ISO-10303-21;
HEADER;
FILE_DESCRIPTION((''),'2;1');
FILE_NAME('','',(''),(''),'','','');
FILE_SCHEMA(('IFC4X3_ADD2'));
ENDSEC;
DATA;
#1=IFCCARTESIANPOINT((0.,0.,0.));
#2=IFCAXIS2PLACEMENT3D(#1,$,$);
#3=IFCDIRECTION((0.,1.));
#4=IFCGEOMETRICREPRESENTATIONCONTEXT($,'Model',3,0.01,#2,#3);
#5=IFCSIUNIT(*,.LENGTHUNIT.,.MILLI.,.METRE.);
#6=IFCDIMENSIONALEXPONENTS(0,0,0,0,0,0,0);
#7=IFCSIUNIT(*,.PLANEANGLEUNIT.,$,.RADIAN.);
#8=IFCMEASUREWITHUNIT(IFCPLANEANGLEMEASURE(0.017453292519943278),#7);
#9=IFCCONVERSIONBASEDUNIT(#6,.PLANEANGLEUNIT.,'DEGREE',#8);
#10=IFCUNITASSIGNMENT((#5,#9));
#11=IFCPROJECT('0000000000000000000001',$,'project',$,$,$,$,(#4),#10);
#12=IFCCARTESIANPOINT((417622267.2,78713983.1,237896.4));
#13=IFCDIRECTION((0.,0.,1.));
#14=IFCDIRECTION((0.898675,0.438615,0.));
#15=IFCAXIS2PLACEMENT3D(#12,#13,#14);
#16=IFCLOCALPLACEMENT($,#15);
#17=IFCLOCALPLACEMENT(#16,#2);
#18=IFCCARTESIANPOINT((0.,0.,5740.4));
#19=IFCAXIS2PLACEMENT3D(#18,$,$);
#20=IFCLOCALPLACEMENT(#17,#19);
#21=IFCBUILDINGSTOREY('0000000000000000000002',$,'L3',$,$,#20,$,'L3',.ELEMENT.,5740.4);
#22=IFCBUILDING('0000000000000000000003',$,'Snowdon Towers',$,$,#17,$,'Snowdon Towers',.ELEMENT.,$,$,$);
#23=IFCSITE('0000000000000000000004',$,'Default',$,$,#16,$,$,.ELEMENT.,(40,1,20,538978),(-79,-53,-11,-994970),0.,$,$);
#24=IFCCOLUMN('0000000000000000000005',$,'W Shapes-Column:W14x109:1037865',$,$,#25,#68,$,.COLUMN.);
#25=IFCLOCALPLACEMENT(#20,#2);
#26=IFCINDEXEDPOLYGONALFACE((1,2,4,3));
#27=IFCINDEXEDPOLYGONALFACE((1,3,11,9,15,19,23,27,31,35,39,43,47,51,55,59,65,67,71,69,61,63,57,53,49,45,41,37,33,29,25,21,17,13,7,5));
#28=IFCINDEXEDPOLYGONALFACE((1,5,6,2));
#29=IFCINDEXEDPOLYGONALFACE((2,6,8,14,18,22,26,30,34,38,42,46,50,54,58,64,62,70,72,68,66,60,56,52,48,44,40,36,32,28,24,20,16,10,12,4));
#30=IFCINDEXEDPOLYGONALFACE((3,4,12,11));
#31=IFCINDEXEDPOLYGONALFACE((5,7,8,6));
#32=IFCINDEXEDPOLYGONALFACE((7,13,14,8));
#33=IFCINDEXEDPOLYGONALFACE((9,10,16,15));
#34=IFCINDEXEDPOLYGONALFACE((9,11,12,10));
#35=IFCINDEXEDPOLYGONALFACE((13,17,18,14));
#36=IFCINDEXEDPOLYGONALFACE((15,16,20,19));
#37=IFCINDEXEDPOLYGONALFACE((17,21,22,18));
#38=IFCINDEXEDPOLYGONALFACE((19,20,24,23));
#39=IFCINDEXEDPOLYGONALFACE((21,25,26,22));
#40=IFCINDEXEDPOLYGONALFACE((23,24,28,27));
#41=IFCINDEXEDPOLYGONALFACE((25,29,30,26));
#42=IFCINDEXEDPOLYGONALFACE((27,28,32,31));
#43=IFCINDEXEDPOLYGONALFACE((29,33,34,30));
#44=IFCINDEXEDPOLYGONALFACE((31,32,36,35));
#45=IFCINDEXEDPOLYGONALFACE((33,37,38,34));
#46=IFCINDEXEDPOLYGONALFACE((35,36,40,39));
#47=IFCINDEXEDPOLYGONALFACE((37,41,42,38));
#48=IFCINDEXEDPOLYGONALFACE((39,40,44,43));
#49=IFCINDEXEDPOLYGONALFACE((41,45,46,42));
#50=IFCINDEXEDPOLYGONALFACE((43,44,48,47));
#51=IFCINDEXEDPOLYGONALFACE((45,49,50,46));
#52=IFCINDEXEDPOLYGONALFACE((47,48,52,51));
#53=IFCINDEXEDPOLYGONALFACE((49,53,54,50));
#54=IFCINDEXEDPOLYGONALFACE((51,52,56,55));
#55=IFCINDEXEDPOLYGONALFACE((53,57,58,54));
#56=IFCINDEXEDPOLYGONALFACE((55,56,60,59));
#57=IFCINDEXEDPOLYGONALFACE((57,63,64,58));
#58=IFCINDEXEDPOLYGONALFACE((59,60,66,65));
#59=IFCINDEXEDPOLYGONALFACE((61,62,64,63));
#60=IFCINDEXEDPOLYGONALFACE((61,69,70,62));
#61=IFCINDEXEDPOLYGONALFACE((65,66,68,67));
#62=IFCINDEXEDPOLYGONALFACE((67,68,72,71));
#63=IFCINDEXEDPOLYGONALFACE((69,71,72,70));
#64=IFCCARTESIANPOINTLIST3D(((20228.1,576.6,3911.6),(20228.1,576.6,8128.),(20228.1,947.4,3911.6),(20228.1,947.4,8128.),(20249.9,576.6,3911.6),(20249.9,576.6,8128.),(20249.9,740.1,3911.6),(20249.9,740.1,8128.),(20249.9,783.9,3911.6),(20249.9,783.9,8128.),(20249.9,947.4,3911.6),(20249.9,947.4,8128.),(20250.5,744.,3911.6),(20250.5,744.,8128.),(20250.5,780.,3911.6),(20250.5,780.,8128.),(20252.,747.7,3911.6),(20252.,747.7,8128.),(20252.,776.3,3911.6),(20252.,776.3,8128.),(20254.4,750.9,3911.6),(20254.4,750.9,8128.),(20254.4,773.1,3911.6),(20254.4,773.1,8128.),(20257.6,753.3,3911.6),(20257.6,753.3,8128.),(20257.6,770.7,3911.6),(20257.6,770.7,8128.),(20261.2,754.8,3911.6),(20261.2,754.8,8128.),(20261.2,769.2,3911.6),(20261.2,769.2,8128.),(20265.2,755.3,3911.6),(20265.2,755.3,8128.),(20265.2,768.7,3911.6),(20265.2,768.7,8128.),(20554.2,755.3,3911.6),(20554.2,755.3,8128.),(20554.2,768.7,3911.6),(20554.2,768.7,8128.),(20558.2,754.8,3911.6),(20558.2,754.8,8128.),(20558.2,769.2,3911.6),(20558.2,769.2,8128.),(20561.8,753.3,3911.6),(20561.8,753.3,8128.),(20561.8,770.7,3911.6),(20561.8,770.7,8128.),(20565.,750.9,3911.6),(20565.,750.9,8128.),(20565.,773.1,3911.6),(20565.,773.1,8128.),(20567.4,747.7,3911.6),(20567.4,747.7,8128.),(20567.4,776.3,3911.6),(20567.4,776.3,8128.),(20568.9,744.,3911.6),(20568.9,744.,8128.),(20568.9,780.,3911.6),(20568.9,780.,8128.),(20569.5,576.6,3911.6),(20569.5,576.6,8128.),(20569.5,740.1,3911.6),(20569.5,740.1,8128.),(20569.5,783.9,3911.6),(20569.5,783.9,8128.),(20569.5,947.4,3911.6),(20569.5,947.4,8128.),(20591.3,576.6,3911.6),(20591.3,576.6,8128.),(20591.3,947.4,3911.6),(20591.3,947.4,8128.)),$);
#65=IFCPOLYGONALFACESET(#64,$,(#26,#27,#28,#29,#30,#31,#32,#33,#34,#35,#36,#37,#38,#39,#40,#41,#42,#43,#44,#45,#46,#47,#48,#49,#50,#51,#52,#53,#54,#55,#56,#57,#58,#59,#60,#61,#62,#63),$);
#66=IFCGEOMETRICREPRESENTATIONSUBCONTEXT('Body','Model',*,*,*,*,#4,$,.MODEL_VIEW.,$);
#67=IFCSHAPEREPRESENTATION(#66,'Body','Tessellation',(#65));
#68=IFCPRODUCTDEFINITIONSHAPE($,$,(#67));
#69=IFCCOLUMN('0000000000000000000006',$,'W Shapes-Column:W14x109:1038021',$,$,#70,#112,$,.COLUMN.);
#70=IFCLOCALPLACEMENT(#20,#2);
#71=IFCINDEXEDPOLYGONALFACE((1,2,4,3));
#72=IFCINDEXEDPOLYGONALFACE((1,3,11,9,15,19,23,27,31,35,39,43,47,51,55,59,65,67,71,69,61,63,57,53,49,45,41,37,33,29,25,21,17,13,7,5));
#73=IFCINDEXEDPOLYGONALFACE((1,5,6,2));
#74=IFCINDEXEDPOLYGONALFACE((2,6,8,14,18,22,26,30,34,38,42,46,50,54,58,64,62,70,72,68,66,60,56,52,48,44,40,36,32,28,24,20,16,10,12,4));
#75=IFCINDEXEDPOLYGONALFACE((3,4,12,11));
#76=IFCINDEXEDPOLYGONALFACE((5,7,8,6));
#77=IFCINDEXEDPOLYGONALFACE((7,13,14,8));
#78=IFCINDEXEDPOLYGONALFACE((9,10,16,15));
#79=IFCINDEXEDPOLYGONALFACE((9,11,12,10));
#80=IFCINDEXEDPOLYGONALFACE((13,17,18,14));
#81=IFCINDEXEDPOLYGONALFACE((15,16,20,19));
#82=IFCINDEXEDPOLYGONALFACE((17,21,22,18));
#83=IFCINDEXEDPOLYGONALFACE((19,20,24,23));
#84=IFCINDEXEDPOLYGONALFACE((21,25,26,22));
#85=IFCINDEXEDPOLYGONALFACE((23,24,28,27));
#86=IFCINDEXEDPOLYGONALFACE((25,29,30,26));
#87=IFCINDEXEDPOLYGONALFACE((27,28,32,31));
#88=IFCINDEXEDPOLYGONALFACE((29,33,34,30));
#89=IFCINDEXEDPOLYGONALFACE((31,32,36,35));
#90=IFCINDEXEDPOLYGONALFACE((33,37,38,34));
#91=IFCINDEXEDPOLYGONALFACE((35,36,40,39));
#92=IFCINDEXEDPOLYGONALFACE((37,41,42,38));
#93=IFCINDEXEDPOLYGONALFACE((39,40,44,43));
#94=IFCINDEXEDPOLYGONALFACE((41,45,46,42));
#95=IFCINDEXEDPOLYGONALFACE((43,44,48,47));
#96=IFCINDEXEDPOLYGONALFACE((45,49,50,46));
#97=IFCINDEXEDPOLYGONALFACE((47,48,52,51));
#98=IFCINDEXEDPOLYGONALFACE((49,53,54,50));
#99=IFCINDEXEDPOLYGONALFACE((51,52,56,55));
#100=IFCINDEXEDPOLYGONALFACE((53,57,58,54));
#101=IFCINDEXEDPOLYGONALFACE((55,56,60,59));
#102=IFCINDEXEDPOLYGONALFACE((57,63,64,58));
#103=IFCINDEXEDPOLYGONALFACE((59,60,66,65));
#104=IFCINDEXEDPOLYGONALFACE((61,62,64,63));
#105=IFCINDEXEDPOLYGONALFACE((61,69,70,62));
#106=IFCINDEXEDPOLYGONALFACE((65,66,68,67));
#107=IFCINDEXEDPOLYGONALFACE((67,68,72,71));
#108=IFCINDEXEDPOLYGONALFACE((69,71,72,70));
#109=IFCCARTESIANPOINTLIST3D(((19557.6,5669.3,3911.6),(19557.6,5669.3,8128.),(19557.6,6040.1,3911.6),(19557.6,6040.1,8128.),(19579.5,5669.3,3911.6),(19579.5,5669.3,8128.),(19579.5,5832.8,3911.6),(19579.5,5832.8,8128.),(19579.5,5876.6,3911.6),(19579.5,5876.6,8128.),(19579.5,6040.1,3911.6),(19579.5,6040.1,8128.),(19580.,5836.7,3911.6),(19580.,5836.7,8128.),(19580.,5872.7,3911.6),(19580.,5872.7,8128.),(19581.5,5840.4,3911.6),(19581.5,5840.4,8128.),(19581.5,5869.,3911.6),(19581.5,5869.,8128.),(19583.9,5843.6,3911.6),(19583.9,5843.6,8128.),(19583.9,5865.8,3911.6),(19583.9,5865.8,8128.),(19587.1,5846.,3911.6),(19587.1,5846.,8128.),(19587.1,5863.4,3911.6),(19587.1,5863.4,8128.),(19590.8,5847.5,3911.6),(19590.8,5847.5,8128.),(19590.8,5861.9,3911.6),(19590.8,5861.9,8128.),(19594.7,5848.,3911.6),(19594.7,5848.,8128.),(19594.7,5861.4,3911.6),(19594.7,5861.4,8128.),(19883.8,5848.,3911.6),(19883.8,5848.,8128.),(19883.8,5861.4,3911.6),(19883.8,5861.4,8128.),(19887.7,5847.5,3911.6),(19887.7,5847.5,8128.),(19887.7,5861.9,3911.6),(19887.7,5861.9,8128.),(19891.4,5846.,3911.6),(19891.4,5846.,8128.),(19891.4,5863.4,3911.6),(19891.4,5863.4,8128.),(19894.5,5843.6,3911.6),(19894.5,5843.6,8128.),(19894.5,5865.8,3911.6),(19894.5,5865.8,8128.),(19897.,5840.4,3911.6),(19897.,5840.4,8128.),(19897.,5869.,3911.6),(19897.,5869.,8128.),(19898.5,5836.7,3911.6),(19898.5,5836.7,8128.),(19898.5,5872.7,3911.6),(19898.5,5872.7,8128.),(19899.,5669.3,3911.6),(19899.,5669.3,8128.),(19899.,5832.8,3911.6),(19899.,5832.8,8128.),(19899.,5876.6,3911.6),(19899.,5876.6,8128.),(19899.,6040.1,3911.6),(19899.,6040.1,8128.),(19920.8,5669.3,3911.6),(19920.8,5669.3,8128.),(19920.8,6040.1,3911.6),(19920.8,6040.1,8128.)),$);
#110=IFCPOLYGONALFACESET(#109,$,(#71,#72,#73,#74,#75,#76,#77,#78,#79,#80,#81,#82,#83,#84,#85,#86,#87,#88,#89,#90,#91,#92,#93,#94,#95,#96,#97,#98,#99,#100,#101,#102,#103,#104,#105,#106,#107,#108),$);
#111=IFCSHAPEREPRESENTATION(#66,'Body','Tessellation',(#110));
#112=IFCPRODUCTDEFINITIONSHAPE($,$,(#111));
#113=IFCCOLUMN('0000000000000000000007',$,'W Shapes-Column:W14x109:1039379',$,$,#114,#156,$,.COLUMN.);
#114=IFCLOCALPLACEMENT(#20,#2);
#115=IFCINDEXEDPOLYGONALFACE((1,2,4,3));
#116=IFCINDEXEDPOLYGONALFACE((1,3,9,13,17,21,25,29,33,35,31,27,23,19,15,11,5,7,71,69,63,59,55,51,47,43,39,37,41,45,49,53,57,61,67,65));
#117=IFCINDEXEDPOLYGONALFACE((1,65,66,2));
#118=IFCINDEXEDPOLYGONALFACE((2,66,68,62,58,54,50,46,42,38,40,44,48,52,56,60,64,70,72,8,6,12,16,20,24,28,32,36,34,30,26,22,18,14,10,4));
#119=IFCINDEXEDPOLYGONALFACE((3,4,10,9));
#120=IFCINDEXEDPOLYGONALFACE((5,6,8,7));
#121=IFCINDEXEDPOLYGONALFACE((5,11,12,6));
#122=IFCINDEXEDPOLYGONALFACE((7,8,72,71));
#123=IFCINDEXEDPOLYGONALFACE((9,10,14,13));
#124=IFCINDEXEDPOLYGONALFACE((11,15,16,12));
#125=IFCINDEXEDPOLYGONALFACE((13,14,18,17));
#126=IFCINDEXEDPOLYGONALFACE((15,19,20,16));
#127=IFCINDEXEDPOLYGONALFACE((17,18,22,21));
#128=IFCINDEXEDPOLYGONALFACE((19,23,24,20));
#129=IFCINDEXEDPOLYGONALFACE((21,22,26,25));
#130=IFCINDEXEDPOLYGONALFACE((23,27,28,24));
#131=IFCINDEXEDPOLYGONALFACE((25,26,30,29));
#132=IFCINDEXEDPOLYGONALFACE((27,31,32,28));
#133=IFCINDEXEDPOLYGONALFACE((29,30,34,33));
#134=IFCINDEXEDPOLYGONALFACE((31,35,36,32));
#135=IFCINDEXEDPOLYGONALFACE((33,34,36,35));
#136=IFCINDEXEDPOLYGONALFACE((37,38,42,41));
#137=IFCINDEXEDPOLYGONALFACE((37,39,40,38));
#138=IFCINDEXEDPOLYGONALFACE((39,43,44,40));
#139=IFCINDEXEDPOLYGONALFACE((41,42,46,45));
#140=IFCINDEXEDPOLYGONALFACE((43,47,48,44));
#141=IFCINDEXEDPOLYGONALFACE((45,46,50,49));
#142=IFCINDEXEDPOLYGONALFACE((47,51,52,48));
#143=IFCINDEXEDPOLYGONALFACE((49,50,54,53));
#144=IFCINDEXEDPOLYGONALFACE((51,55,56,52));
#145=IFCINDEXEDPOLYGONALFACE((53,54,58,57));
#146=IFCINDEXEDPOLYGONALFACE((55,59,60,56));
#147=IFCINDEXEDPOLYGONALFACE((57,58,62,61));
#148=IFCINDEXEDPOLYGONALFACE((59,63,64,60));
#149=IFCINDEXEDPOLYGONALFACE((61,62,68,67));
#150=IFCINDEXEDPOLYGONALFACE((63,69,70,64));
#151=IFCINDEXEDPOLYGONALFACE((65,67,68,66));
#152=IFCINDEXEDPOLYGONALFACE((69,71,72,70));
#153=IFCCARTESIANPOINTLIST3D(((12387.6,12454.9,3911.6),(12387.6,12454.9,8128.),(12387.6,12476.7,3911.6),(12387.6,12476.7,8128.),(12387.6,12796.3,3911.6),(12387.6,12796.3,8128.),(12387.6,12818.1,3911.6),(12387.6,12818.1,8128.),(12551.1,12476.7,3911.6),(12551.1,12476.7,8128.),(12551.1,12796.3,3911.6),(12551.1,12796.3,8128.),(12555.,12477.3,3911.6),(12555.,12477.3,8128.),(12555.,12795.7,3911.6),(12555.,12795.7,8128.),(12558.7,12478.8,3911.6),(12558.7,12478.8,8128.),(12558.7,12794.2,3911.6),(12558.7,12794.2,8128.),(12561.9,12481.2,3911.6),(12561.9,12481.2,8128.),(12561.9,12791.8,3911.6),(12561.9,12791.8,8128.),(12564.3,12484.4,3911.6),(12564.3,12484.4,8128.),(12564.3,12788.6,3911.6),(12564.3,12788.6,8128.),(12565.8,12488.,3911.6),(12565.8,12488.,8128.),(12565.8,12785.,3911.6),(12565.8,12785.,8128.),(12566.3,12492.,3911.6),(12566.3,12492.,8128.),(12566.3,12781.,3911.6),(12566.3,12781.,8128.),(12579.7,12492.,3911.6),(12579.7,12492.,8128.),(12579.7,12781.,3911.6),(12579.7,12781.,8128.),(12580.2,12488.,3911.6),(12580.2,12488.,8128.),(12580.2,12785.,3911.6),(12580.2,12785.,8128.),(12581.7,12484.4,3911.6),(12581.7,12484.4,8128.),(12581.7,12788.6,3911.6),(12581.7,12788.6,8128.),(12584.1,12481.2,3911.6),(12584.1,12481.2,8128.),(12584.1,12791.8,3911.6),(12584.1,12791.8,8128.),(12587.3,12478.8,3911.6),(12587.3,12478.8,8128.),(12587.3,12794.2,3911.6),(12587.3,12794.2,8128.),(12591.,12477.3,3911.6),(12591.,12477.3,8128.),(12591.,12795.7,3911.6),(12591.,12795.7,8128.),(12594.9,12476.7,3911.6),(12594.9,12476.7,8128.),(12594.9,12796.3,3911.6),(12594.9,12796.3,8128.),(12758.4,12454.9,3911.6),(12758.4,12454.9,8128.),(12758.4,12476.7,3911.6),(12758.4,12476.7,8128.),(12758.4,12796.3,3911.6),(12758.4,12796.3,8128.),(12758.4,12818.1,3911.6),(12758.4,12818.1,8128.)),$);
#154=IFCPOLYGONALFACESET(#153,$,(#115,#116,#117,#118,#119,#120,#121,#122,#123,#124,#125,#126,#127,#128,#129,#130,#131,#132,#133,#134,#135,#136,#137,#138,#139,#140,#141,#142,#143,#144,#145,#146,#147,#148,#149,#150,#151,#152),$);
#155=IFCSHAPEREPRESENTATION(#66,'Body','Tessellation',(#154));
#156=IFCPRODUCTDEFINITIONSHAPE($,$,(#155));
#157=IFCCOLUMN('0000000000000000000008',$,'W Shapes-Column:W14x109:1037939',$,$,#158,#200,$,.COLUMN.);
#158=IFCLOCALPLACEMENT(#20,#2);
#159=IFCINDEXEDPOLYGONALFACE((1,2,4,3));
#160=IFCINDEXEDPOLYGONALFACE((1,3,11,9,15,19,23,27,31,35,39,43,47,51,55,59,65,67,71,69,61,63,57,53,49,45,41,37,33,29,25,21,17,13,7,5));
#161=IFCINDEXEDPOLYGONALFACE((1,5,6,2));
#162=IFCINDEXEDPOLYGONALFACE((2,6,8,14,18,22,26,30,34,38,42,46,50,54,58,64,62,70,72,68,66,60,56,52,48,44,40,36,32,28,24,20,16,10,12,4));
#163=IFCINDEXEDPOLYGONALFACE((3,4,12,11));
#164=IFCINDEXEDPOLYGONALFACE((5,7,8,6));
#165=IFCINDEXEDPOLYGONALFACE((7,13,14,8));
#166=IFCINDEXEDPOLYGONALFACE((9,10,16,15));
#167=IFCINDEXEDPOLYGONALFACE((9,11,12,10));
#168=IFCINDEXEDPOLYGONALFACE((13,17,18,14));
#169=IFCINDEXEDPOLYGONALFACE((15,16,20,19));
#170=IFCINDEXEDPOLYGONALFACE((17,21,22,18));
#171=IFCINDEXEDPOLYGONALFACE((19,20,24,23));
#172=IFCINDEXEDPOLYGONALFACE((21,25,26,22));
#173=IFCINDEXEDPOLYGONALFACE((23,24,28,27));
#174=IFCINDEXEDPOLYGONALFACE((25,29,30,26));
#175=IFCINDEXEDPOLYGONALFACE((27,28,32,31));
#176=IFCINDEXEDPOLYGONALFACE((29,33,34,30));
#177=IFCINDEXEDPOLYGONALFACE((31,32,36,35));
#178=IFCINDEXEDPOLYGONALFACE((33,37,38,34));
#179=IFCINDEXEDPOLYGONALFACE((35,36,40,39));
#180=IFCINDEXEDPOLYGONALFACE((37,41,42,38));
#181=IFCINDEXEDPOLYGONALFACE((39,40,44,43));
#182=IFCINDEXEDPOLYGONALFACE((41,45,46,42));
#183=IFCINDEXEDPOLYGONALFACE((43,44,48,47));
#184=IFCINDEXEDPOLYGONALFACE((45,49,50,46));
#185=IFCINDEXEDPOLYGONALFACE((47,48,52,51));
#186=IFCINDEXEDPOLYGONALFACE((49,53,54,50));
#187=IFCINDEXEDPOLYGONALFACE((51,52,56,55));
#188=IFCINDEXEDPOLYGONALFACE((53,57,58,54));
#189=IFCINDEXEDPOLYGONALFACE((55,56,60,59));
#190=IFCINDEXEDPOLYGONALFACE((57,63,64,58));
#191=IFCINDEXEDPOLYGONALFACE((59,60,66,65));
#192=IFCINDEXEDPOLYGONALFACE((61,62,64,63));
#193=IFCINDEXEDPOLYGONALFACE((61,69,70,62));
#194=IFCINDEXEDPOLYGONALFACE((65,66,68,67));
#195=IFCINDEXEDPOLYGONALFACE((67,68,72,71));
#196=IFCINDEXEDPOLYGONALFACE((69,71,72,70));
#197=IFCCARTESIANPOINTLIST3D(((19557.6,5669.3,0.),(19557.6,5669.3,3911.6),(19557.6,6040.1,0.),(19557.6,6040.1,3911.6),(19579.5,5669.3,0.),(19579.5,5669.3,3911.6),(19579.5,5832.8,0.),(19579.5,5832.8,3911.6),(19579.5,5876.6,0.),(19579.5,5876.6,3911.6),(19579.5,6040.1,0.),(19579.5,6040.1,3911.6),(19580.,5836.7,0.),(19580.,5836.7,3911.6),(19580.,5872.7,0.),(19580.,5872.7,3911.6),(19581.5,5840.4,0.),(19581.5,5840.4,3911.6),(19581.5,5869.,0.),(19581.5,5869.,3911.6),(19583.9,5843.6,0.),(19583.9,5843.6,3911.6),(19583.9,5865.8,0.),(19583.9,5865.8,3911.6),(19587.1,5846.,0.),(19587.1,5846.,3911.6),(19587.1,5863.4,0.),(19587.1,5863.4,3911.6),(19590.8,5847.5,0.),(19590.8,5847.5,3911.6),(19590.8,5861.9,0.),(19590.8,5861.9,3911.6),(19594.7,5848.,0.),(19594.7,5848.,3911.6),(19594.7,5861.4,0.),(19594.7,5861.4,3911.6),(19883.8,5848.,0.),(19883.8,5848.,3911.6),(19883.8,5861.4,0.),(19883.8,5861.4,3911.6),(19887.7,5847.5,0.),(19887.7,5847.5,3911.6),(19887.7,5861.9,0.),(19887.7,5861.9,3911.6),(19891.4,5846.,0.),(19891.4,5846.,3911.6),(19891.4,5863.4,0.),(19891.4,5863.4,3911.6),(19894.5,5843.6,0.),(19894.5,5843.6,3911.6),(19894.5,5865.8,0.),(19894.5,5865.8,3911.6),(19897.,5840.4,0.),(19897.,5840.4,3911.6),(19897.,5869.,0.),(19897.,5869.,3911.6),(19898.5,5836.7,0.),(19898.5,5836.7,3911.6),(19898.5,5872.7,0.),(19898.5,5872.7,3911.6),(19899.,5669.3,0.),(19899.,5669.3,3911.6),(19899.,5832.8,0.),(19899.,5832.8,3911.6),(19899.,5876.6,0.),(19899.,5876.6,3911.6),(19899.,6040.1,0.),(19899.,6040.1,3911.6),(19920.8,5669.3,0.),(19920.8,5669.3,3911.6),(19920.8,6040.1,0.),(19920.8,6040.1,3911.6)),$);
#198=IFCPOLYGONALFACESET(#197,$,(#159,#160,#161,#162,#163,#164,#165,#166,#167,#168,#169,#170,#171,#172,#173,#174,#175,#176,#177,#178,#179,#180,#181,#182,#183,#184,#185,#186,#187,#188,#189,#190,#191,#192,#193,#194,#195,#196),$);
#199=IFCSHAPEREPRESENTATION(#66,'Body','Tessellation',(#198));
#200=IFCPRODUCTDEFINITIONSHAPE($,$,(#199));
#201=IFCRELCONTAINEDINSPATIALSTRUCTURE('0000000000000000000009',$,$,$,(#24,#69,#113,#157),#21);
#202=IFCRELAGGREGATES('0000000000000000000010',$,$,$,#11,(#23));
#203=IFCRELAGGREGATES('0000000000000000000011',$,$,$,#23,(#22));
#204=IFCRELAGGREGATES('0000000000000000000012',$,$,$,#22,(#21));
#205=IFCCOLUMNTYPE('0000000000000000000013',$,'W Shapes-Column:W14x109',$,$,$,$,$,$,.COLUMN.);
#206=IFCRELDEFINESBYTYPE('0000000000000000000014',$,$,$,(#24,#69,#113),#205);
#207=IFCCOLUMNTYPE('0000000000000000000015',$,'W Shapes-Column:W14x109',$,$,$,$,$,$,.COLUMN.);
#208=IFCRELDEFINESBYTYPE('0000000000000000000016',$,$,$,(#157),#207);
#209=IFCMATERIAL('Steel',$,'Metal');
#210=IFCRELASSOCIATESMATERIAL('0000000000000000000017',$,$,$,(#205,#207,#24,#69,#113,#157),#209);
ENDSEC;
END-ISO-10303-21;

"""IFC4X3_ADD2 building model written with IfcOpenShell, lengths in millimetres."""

from ifc_helpers import new_model, entity, si_unit, converted_unit, direction, frame, frame_2d, origin, place, context, subcontext, project, spatial, i_section, extrude, source, transform, mapped, material, material_profile, profile_set, profile_usage, type_object, type_shapes, element, save


model = new_model("IFC4X3_ADD2")

# Units and contexts
model_context = context("Model", 3, precision=0.01, world=origin(), true_north=direction((0.0, 1.0)))
body_context = subcontext(model_context, "Body", "Model", "MODEL_VIEW")
ifc_project = project(units=[si_unit("LENGTHUNIT", "METRE", prefix="MILLI"), converted_unit("PLANEANGLEUNIT", "DEGREE", entity("IfcPlaneAngleMeasure", 0.017453292519943278), si_unit("PLANEANGLEUNIT", "RADIAN"), dimensions=[0, 0, 0, 0, 0, 0, 0])], contexts=[model_context])

# Site, building, storey
site_placement = place(None, frame((417622267.2, 78713983.1, 237896.4), z_axis=(0.0, 0.0, 1.0), x_axis=(0.898675, 0.438615, 0.0)))
site = spatial("IfcSite", under=ifc_project, at=site_placement, Name="Default", CompositionType="ELEMENT", RefLatitude=(40, 1, 20, 538978), RefLongitude=(-79, -53, -11, -994970), RefElevation=0.0)
building_placement = place(site_placement, origin())
building = spatial("IfcBuilding", under=site, at=building_placement, Name="Snowdon Towers", LongName="Snowdon Towers", CompositionType="ELEMENT")
storey_placement = place(building_placement, frame((0.0, 0.0, 5740.4)))
storey = spatial("IfcBuildingStorey", under=building, at=storey_placement, Name="L3", LongName="L3", CompositionType="ELEMENT", Elevation=5740.4)

# Columns
ifc_material_1 = material(Name="Steel", Category="Metal")
ifc_material_profile_1 = material_profile(ifc_material_1, i_section(OverallWidth=370.8, OverallDepth=363.2, WebThickness=13.3, FlangeThickness=21.8, FilletRadius=15.2, at=frame_2d((0.0, 0.0), x_axis=(1.0, 0.0))), Name="W14x109")
ifc_profile_set_1 = profile_set([ifc_material_profile_1], Name="W14x109")
ifc_profile_usage_1 = profile_usage(ifc_profile_set_1)
column_type_1 = type_object("IfcColumnType", Name="W Shapes-Column:W14x109", PredefinedType="COLUMN", material=ifc_profile_set_1)
shared_shape_1 = source(origin(), body_context, "Body", "SweptSolid", [
    extrude(i_section(OverallWidth=370.8, OverallDepth=363.2, WebThickness=13.3, FlangeThickness=21.8, FilletRadius=15.2, at=frame_2d((0.0, 0.0), x_axis=(1.0, 0.0))), frame((0.0, 0.0, 9652.0), z_axis=(0.0, 0.0, 1.0), x_axis=(-1.0, 0.0, 0.0)), (0.0, 0.0, 1.0), 4216.4),
])
type_shapes(column_type_1, [shared_shape_1])
for number, where, z_axis, x_axis, name in (
    (1, (20409.7, 762.0, -5740.4), (0.0, 0.0, 1.0), (0.0, 1.0, 0.0), "W Shapes-Column:W14x109:1037865"),
    (2, (19739.2, 5854.7, -5740.4), (0.0, 0.0, 1.0), (0.0, 1.0, 0.0), "W Shapes-Column:W14x109:1038021"),
    (3, (12573.0, 12636.5, -5740.4), (0.0, 0.0, 1.0), (-1.0, 0.0, 0.0), "W Shapes-Column:W14x109:1039379"),
):
    element("IfcColumn", number, at=place(storey_placement, frame(where, z_axis=z_axis, x_axis=x_axis)), inside=storey, type_object=column_type_1, material=ifc_profile_usage_1, Name=name, PredefinedType="COLUMN", context=body_context, shape_type="MappedRepresentation", body=[
        mapped(shared_shape_1, transform((0.0, 0.0, 0.0), scale=1.0)),
    ])
column_type_2 = type_object("IfcColumnType", Name="W Shapes-Column:W14x109", PredefinedType="COLUMN", material=ifc_profile_set_1)
shared_shape_2 = source(origin(), body_context, "Body", "SweptSolid", [
    extrude(i_section(OverallWidth=370.8, OverallDepth=363.2, WebThickness=13.3, FlangeThickness=21.8, FilletRadius=15.2, at=frame_2d((0.0, 0.0), x_axis=(1.0, 0.0))), frame((0.0, 0.0, 5740.4), z_axis=(0.0, 0.0, 1.0), x_axis=(-1.0, 0.0, 0.0)), (0.0, 0.0, 1.0), 3911.6),
])
type_shapes(column_type_2, [shared_shape_2])
column_1_placement = place(storey_placement, frame((19739.2, 5854.7, -5740.4), z_axis=(0.0, 0.0, 1.0), x_axis=(0.0, 1.0, 0.0)))
element("IfcColumn", 4, at=column_1_placement, inside=storey, type_object=column_type_2, material=ifc_profile_usage_1, Name="W Shapes-Column:W14x109:1037939", PredefinedType="COLUMN", context=body_context, shape_type="MappedRepresentation", body=[
    mapped(shared_shape_2, transform((0.0, 0.0, 0.0), scale=1.0)),
])

save(model, "model.ifc")
